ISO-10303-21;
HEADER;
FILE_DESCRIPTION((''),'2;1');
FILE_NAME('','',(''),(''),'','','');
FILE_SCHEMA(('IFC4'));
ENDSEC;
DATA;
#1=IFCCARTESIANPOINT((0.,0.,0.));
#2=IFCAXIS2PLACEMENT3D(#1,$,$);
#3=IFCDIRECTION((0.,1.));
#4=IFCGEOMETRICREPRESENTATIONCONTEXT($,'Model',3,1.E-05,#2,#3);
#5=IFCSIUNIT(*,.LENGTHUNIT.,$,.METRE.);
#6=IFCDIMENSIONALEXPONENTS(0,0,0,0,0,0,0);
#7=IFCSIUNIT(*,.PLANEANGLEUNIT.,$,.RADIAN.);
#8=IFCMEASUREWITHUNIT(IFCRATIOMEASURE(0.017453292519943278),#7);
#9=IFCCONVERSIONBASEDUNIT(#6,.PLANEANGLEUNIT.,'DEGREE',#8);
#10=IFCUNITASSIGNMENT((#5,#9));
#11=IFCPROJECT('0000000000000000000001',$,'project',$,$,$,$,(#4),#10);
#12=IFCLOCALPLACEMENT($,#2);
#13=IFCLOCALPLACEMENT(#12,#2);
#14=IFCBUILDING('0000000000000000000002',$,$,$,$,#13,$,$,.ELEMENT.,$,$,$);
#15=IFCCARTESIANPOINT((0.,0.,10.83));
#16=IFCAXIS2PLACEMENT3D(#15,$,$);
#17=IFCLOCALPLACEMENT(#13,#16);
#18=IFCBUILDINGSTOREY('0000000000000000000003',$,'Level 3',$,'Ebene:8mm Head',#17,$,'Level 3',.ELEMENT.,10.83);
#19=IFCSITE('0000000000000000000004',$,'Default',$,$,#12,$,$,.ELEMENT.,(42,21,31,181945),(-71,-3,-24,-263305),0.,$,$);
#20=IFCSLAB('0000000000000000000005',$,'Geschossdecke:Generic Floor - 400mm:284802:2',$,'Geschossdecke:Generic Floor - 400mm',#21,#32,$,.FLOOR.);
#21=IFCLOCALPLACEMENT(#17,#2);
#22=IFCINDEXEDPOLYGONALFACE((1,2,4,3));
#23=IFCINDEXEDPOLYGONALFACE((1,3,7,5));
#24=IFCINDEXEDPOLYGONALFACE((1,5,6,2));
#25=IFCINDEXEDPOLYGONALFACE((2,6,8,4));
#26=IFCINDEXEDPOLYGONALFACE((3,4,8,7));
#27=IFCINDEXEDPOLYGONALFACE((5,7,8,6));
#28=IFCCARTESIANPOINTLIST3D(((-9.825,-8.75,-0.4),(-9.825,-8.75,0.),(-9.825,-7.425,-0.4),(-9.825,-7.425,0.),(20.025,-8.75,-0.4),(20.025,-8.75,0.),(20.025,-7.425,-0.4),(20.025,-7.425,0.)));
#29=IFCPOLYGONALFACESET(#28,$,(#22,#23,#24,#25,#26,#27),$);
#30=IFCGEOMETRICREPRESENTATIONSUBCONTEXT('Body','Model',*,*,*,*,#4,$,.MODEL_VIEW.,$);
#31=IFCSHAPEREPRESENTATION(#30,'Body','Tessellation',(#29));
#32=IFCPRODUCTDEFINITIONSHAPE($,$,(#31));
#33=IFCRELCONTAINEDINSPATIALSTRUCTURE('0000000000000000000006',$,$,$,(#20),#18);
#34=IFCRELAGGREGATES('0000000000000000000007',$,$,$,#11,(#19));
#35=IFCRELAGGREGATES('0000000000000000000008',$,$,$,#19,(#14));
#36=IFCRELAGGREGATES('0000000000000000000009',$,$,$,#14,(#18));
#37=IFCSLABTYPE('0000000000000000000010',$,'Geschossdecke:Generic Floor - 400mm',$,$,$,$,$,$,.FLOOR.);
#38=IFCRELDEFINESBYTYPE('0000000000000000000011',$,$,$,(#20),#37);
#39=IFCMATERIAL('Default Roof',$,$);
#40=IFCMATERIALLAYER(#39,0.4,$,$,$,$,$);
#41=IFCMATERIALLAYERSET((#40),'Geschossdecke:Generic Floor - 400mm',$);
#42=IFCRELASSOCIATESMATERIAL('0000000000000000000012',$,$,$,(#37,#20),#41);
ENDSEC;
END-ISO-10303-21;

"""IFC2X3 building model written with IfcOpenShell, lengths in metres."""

from ifc_helpers import new_model, entity, si_unit, converted_unit, direction, frame, frame_2d, origin, place, context, subcontext, project, spatial, rectangle, extrude, material, layer, layer_set, layer_usage, type_object, element, save


model = new_model("IFC2X3")

# Units and contexts
model_context = context("Model", 3, precision=1e-05, world=origin(), true_north=direction((0.0, 1.0)))
body_context = subcontext(model_context, "Body", "Model", "MODEL_VIEW")
ifc_project = project(units=[si_unit("LENGTHUNIT", "METRE"), converted_unit("PLANEANGLEUNIT", "DEGREE", entity("IfcRatioMeasure", 0.017453292519943278), si_unit("PLANEANGLEUNIT", "RADIAN"), dimensions=[0, 0, 0, 0, 0, 0, 0])], contexts=[model_context])

# Site, building, storey
site_placement = place(None, origin())
site = spatial("IfcSite", under=ifc_project, at=site_placement, Name="Default", CompositionType="ELEMENT", RefLatitude=(42, 21, 31, 181945), RefLongitude=(-71, -3, -24, -263305), RefElevation=0.0)
building_placement = place(site_placement, origin())
building = spatial("IfcBuilding", under=site, at=building_placement, CompositionType="ELEMENT")
storey_placement = place(building_placement, frame((0.0, 0.0, 10.83)))
storey = spatial("IfcBuildingStorey", under=building, at=storey_placement, Name="Level 3", ObjectType="Ebene:8mm Head", LongName="Level 3", CompositionType="ELEMENT", Elevation=10.83)

# Shared definitions
ifc_material = material(Name="Default Roof")
ifc_layer = layer(ifc_material, 0.4)
ifc_layer_set = layer_set([ifc_layer], Name="Geschossdecke:Generic Floor - 400mm")
ifc_layer_usage = layer_usage(ifc_layer_set, "AXIS3", "POSITIVE", 0.0)
slab_type = type_object("IfcSlabType", Name="Geschossdecke:Generic Floor - 400mm", PredefinedType="FLOOR", material=ifc_layer_set)

# Slab
slab_1_placement = place(storey_placement, frame((-9.825, -8.75, -0.4)))
element("IfcSlab", 1, at=slab_1_placement, inside=storey, type_object=slab_type, material=ifc_layer_usage, Name="Geschossdecke:Generic Floor - 400mm:284802:2", ObjectType="Geschossdecke:Generic Floor - 400mm", PredefinedType="FLOOR", context=body_context, shape_type="SweptSolid", body=[
    extrude(rectangle(XDim=29.85, YDim=1.325, at=frame_2d((0.0, -10.0), x_axis=(1.0, 0.0))), frame((14.925, 10.6625, 0.4), z_axis=(0.0, 0.0, -1.0), x_axis=(-1.0, 0.0, 0.0)), (0.0, 0.0, 1.0), 0.4),
])

save(model, "model.ifc")
